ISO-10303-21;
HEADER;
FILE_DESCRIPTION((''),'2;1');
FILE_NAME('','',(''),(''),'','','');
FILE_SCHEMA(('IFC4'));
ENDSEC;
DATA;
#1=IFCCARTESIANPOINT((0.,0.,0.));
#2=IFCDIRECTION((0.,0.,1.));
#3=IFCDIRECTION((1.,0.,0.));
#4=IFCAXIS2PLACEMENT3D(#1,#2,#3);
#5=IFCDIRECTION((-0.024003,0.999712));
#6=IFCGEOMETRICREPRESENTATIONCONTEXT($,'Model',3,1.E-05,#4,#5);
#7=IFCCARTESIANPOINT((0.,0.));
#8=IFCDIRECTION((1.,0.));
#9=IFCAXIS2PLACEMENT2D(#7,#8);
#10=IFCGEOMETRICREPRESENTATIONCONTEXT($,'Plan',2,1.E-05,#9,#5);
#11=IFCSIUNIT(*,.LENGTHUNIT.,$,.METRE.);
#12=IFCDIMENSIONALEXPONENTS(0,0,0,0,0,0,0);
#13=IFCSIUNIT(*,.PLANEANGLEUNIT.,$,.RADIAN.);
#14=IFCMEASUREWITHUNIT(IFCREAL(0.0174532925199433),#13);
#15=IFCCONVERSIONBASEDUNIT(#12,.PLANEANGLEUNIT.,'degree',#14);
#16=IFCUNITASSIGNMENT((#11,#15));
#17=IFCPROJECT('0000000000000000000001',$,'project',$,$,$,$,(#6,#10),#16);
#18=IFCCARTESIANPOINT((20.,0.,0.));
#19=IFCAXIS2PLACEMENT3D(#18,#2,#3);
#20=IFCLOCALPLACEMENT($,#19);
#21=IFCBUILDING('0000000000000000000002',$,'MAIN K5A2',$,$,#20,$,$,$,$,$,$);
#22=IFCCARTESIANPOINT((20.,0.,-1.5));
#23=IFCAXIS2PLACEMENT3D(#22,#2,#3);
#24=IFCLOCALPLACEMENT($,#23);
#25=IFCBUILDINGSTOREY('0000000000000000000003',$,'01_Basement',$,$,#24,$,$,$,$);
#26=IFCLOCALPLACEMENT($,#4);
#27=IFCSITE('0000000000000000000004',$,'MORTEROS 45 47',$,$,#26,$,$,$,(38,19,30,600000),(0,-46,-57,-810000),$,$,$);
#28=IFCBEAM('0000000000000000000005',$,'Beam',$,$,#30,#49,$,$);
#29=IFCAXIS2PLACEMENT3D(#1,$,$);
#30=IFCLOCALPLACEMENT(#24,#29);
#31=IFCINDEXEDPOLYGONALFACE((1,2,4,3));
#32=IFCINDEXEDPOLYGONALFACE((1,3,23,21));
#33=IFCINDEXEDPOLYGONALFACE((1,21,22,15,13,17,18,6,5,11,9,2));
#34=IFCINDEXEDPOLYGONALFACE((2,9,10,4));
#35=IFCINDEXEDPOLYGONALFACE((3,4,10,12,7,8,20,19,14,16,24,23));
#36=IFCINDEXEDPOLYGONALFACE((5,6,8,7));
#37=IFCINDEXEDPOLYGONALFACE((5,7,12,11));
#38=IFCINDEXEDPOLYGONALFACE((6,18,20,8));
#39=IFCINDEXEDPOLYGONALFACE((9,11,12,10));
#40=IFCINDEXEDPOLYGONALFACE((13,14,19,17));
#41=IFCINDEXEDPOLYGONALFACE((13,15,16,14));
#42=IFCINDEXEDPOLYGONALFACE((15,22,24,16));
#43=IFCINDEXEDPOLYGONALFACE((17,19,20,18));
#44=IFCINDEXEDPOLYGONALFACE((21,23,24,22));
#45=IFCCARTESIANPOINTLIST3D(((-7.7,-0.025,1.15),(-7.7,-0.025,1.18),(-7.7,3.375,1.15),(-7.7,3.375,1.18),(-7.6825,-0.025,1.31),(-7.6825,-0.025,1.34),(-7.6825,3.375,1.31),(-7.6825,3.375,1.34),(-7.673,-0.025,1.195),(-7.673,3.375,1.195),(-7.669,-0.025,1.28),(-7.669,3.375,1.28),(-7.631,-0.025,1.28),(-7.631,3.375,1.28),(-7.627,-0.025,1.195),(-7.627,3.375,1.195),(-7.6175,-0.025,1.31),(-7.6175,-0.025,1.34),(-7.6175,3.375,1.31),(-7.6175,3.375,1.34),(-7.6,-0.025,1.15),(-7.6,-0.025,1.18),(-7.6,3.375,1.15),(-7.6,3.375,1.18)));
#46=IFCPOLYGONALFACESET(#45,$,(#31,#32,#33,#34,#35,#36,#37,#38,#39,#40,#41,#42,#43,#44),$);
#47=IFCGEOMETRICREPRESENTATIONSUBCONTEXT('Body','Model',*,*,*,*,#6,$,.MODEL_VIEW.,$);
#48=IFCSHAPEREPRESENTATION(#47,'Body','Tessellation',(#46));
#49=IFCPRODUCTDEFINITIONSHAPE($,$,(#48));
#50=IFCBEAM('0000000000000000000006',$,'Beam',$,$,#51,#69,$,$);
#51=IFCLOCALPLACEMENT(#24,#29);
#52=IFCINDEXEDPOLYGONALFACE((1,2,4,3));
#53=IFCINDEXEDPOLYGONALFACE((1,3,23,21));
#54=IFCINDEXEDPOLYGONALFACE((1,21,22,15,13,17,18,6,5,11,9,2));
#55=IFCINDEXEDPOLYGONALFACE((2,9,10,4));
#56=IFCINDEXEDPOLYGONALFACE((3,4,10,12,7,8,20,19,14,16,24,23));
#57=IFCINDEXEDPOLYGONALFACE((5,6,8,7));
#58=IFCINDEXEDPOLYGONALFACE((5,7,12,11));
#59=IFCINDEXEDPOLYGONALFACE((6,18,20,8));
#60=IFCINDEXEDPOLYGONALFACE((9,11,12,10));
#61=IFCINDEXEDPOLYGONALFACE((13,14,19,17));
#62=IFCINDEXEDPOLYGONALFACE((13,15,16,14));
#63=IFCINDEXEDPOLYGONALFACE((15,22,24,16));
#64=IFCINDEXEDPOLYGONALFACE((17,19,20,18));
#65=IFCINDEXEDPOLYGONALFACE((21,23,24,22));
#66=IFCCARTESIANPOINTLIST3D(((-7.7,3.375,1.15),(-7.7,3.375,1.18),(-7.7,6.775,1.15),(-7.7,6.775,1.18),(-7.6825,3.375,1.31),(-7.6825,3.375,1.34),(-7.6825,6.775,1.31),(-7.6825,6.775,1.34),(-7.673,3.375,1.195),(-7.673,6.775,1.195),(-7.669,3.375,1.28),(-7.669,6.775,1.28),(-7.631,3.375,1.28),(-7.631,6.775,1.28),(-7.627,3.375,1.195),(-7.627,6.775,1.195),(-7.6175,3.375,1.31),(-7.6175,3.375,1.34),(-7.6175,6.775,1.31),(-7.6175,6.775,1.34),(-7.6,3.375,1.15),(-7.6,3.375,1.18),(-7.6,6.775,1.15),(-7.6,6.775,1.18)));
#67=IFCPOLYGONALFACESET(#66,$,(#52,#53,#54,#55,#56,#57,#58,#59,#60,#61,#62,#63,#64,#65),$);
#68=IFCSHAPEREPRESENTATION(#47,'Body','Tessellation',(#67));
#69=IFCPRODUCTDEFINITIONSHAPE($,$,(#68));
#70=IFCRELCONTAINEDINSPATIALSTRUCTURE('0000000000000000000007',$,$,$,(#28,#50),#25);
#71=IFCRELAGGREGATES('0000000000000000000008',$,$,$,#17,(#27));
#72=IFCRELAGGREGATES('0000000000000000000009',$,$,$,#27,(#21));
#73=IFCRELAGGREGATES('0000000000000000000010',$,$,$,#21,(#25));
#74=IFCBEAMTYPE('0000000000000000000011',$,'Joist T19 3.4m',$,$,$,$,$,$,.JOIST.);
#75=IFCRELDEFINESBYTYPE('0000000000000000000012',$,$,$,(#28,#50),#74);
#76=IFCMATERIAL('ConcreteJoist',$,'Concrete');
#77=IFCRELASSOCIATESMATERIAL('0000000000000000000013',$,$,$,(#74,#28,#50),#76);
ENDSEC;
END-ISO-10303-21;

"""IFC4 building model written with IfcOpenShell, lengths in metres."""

from ifc_helpers import new_model, entity, si_unit, converted_unit, direction, frame, origin_with_axes, origin_2d_with_axis, place, context, subcontext, project, spatial, indexed_curve, outline, extrude, material, material_profile, profile_set, profile_usage, type_object, element, save


model = new_model("IFC4")

# Units and contexts
model_context = context("Model", 3, precision=1e-05, world=origin_with_axes(), true_north=direction((-0.024003, 0.999712)))
plan_context = context("Plan", 2, precision=1e-05, world=origin_2d_with_axis(), true_north=direction((-0.024003, 0.999712)))
body_context_1 = subcontext(model_context, "Body", "Model", "MODEL_VIEW")
ifc_project = project(units=[si_unit("LENGTHUNIT", "METRE"), converted_unit("PLANEANGLEUNIT", "degree", entity("IfcReal", 0.0174532925199433), si_unit("PLANEANGLEUNIT", "RADIAN"), dimensions=[0, 0, 0, 0, 0, 0, 0])], contexts=[model_context, plan_context])

# Site, building, storey
site_placement = place(None, origin_with_axes())
site = spatial("IfcSite", under=ifc_project, at=site_placement, Name="MORTEROS 45 47", RefLatitude=(38, 19, 30, 600000), RefLongitude=(0, -46, -57, -810000))
building_placement = place(None, frame((20.0, 0.0, 0.0), z_axis=(0.0, 0.0, 1.0), x_axis=(1.0, 0.0, 0.0)))
building = spatial("IfcBuilding", under=site, at=building_placement, Name="MAIN K5A2")
storey_placement = place(None, frame((20.0, 0.0, -1.5), z_axis=(0.0, 0.0, 1.0), x_axis=(1.0, 0.0, 0.0)))
storey = spatial("IfcBuildingStorey", under=building, at=storey_placement, Name="01_Basement")

# Beams
ifc_material = material(Name="ConcreteJoist", Category="Concrete")
ifc_material_profile = material_profile(ifc_material, outline(indexed_curve([(0.019, 0.13), (0.023, 0.045), (0.05, 0.03), (0.05, 0.0), (-0.05, 0.0), (-0.05, 0.03), (-0.023, 0.045), (-0.019, 0.13), (-0.0325, 0.16), (-0.0325, 0.19), (0.0325, 0.19), (0.0325, 0.16), (0.019, 0.13)])))
ifc_profile_set = profile_set([ifc_material_profile], Name="JoistMaterialProfileSet")
beam_type = type_object("IfcBeamType", Name="Joist T19 3.4m", PredefinedType="JOIST", material=ifc_profile_set)
ifc_profile_usage_1 = profile_usage(ifc_profile_set, cardinal=5)
beam_1_placement = place(None, frame((12.35, -0.025, -0.35), z_axis=(0.0, 1.0, 0.0), x_axis=(-1.0, 0.0, 0.0)))
element("IfcBeam", 1, at=beam_1_placement, inside=storey, type_object=beam_type, material=ifc_profile_usage_1, Name="Beam", context=body_context_1, shape_type="SweptSolid", body=[
    extrude(outline(indexed_curve([(0.019, 0.13), (0.023, 0.045), (0.05, 0.03), (0.05, 0.0), (-0.05, 0.0), (-0.05, 0.03), (-0.023, 0.045), (-0.019, 0.13), (-0.0325, 0.16), (-0.0325, 0.19), (0.0325, 0.19), (0.0325, 0.16), (0.019, 0.13)])), origin_with_axes(), (0.0, 0.0, 1.0), 3.4),
])
ifc_profile_usage_2 = profile_usage(ifc_profile_set, cardinal=5)
beam_2_placement = place(None, frame((12.35, 3.375, -0.35), z_axis=(0.0, 1.0, 0.0), x_axis=(-1.0, 0.0, 0.0)))
element("IfcBeam", 2, at=beam_2_placement, inside=storey, type_object=beam_type, material=ifc_profile_usage_2, Name="Beam", context=body_context_1, shape_type="SweptSolid", body=[
    extrude(outline(indexed_curve([(0.019, 0.13), (0.023, 0.045), (0.05, 0.03), (0.05, 0.0), (-0.05, 0.0), (-0.05, 0.03), (-0.023, 0.045), (-0.019, 0.13), (-0.0325, 0.16), (-0.0325, 0.19), (0.0325, 0.19), (0.0325, 0.16), (0.019, 0.13)])), origin_with_axes(), (0.0, 0.0, 1.0), 3.4),
])

save(model, "model.ifc")
